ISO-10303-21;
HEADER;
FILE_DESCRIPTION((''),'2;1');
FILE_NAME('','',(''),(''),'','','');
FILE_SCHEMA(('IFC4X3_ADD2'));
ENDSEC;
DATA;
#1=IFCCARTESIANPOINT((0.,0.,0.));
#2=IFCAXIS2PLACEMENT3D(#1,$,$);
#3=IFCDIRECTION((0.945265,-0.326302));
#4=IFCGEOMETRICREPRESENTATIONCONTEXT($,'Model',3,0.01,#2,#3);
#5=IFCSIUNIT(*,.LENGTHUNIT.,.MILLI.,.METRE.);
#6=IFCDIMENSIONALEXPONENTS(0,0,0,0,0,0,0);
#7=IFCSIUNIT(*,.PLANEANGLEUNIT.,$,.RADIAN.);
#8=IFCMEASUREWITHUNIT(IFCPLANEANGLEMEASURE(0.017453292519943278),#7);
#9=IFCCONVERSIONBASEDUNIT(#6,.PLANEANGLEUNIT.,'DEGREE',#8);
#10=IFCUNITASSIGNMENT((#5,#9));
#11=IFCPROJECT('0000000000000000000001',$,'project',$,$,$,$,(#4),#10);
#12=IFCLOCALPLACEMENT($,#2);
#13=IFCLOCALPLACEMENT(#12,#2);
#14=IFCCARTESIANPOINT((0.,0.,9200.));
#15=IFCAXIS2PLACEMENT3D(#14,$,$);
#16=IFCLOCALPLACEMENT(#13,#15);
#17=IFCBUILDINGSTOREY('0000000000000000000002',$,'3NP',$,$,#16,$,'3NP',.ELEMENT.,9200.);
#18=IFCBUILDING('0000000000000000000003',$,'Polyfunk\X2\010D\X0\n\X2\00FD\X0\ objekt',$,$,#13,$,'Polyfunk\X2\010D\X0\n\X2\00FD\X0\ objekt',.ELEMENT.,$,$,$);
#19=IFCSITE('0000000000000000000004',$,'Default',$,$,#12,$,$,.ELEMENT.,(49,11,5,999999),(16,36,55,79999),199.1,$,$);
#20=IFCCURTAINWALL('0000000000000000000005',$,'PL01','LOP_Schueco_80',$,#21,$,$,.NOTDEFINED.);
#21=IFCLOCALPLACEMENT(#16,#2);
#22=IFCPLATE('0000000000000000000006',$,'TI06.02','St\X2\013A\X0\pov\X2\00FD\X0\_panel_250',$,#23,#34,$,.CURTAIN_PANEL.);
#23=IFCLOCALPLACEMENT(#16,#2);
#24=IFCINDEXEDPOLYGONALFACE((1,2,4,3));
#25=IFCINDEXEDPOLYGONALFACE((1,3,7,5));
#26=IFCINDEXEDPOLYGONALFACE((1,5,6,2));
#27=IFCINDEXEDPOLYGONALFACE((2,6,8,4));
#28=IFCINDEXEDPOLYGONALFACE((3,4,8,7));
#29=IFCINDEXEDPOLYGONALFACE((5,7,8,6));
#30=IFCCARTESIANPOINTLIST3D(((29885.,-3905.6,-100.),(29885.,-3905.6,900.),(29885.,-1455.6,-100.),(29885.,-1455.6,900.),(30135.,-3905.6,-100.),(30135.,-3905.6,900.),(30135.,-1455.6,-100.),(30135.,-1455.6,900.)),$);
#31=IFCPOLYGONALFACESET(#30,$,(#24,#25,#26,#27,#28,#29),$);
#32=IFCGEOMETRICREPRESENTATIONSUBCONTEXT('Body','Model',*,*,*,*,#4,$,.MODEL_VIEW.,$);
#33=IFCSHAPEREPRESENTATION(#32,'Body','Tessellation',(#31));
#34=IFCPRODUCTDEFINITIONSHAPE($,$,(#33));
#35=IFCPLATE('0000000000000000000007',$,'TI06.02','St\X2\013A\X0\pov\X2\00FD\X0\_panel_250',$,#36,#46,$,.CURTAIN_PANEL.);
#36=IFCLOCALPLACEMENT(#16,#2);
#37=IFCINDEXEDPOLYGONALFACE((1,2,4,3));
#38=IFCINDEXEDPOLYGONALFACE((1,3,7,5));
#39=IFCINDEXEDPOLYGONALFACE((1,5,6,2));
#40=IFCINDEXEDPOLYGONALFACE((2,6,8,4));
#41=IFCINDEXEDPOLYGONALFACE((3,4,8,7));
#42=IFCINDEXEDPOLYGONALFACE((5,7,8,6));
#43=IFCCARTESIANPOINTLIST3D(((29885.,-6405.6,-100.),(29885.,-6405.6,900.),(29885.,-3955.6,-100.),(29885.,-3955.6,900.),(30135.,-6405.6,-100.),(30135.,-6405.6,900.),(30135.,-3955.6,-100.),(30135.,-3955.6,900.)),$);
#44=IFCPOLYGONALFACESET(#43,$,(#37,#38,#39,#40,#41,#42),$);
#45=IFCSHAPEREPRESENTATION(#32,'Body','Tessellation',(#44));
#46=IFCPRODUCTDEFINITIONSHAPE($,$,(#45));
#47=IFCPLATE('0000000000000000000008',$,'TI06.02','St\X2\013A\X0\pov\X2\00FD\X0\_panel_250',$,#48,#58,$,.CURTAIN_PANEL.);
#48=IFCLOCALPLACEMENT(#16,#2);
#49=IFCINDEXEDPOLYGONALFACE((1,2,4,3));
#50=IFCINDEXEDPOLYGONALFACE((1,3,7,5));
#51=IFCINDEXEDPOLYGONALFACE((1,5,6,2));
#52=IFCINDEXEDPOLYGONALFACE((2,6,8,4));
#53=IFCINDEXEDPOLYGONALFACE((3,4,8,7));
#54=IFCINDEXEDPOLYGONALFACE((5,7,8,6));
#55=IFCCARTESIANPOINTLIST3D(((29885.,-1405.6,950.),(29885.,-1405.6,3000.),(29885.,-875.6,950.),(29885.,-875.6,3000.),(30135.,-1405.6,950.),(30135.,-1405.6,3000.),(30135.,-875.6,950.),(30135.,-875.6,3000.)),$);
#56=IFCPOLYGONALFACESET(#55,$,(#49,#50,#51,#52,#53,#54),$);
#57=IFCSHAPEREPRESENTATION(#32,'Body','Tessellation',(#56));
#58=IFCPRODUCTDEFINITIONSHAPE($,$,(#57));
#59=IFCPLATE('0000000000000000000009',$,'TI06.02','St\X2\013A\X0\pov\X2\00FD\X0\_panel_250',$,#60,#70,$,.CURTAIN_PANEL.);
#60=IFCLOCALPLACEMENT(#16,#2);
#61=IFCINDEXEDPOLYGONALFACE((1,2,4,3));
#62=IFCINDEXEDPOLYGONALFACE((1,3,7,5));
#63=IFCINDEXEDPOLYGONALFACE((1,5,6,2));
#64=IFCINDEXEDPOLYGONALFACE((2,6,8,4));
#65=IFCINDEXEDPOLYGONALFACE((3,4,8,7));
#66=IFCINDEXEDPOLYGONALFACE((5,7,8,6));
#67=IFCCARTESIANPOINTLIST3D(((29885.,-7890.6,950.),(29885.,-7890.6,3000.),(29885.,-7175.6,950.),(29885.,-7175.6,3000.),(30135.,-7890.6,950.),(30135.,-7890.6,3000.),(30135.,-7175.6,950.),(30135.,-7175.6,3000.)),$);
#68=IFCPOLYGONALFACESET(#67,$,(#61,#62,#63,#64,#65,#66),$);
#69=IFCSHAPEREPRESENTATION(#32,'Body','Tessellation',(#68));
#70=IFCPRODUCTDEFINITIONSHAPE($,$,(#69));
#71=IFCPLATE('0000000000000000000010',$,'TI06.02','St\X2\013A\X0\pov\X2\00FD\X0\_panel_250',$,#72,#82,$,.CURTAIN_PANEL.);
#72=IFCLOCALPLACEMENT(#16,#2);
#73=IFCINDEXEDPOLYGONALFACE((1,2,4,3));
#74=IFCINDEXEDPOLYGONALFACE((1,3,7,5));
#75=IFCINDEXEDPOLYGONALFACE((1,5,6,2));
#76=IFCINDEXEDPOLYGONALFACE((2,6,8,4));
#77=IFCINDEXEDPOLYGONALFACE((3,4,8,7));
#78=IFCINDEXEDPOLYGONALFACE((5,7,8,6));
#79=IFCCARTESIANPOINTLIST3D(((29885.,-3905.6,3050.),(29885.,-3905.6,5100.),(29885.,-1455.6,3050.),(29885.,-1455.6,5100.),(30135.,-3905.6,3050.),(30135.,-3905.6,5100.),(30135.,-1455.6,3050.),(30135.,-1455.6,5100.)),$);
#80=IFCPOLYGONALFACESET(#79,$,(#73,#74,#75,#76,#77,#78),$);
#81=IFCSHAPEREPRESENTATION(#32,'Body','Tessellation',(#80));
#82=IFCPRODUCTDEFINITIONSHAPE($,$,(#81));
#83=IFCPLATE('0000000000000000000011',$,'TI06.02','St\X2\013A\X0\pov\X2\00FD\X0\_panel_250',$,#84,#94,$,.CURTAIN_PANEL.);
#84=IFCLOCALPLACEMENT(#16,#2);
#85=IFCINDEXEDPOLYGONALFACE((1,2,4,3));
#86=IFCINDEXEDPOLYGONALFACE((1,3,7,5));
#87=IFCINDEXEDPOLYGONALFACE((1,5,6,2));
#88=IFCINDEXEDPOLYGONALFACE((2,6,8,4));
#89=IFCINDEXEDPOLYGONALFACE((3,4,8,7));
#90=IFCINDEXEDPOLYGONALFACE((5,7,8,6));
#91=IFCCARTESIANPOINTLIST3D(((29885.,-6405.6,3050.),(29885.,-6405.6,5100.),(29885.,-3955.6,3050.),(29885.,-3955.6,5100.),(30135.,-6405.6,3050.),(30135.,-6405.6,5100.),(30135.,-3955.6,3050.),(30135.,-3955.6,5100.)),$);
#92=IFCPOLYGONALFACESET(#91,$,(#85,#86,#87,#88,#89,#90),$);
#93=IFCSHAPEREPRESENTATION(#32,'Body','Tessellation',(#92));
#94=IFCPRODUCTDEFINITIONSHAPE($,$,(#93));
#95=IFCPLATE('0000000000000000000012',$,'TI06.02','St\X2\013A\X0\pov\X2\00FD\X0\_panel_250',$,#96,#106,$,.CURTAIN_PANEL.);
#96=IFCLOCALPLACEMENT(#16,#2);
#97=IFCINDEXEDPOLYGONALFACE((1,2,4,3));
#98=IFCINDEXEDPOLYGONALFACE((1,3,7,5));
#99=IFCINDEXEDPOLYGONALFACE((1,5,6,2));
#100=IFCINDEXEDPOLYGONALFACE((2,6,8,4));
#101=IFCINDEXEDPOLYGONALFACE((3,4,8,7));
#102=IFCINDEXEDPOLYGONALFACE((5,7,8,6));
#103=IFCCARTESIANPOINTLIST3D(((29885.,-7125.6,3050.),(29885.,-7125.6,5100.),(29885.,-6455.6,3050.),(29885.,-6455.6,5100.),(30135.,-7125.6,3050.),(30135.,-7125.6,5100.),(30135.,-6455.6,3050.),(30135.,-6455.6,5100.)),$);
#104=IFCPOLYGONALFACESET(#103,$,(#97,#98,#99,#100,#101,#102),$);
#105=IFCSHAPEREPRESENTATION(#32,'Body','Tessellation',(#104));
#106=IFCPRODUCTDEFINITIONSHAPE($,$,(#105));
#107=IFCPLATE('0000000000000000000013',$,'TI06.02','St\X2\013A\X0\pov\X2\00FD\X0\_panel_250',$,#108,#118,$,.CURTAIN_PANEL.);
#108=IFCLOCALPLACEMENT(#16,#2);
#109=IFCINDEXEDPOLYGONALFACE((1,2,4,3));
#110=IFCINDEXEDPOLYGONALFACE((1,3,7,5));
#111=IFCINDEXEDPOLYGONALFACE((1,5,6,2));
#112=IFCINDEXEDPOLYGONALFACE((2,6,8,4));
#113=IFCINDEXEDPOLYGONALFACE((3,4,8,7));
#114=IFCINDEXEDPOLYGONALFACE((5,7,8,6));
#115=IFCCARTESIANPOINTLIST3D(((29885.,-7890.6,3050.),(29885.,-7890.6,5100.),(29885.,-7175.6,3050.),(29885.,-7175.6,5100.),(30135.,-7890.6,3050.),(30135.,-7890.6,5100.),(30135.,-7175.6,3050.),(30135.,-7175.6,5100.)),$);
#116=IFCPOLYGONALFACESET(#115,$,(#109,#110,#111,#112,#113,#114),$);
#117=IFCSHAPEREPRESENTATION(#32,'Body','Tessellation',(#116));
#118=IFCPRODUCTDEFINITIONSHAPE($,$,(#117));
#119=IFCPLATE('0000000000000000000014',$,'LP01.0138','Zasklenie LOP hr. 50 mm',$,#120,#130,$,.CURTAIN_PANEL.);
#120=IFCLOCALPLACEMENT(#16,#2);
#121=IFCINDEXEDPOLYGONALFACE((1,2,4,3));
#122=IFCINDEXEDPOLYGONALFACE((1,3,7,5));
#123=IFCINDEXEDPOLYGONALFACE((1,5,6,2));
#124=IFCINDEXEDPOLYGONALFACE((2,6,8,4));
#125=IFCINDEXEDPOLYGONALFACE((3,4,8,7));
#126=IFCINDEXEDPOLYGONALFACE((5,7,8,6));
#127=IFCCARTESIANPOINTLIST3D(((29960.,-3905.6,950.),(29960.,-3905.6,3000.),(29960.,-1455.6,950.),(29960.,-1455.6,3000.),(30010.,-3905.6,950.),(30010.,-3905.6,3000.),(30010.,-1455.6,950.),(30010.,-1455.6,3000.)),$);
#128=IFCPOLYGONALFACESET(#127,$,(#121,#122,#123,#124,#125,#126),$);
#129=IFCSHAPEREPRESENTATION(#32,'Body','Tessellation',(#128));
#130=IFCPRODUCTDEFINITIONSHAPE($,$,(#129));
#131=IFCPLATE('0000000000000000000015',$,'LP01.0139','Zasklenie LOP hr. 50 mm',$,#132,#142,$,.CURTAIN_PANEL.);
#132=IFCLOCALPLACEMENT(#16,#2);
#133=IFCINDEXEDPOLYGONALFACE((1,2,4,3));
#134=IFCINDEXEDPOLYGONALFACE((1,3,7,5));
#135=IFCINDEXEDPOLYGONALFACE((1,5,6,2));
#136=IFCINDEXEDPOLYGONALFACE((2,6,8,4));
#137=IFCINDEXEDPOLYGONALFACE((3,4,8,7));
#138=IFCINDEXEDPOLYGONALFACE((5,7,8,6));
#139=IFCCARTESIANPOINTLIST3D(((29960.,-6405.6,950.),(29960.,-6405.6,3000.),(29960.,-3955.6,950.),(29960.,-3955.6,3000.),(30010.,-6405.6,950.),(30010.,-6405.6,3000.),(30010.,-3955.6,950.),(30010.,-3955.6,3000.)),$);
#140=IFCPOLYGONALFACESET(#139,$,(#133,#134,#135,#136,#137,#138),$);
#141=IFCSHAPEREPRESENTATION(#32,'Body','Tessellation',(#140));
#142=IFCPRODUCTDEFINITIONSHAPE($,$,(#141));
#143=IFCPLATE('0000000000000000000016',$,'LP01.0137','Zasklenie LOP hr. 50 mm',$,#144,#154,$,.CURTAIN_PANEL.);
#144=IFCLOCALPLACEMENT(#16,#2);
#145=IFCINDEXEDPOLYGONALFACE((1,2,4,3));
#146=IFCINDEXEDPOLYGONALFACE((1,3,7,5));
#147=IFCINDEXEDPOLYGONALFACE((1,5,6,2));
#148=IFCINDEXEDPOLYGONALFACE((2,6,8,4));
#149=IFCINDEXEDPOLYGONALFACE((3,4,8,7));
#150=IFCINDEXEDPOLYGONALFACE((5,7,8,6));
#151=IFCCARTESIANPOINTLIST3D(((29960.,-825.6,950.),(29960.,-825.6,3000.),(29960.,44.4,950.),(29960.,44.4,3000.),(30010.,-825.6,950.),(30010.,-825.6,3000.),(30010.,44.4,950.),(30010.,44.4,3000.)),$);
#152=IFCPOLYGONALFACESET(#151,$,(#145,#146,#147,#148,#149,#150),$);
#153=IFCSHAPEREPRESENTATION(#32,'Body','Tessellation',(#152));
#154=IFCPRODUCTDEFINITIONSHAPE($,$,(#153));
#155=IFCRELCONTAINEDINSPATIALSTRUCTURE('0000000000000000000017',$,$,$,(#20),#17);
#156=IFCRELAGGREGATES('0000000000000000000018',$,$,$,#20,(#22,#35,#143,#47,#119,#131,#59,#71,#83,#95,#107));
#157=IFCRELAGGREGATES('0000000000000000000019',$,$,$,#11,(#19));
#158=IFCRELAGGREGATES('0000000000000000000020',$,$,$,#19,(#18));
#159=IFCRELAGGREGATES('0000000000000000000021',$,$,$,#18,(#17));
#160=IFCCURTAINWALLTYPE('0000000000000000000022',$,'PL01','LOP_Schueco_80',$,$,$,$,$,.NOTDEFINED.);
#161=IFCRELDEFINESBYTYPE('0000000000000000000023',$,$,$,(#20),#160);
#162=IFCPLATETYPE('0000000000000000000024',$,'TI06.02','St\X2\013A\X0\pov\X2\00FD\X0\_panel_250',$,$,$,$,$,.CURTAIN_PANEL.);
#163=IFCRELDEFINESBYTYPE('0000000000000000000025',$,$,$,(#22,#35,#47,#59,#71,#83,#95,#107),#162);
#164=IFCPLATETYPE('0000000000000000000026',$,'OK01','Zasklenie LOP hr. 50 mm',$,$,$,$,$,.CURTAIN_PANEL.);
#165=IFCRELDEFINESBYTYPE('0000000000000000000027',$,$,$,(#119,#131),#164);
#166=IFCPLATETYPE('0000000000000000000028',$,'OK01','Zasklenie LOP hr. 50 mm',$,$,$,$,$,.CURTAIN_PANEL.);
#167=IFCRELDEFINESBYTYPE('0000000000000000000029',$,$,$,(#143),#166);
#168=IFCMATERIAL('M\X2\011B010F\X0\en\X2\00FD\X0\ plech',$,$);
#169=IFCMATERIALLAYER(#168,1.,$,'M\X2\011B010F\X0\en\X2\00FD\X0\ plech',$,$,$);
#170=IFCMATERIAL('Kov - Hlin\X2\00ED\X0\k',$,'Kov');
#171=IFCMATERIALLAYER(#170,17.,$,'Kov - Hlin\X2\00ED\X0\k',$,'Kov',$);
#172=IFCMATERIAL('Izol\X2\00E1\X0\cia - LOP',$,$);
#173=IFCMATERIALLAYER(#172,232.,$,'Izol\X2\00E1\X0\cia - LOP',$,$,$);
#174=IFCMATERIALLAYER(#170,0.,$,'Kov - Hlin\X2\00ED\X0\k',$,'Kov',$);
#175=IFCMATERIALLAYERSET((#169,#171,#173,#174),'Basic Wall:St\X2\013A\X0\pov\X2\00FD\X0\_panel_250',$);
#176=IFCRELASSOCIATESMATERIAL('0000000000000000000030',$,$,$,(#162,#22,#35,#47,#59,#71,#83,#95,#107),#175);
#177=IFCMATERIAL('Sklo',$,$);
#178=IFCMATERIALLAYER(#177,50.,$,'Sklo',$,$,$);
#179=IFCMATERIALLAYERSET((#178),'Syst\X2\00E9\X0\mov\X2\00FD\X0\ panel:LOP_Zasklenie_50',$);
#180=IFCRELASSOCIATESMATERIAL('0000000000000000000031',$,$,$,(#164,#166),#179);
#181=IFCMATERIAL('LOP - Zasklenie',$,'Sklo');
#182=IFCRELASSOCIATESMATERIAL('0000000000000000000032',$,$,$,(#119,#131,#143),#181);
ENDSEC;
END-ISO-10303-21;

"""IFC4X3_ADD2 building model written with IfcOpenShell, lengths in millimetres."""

from ifc_helpers import new_model, entity, si_unit, converted_unit, direction, frame, frame_2d, origin, origin_2d_with_axis, place, context, subcontext, project, spatial, rectangle, extrude, source, transform, mapped, material, layer, layer_set, layer_usage, type_object, type_shapes, element, aggregate, save


model = new_model("IFC4X3_ADD2")

# Units and contexts
model_context = context("Model", 3, precision=0.01, world=origin(), true_north=direction((0.945265, -0.326302)))
body_context = subcontext(model_context, "Body", "Model", "MODEL_VIEW")
ifc_project = project(units=[si_unit("LENGTHUNIT", "METRE", prefix="MILLI"), converted_unit("PLANEANGLEUNIT", "DEGREE", entity("IfcPlaneAngleMeasure", 0.017453292519943278), si_unit("PLANEANGLEUNIT", "RADIAN"), dimensions=[0, 0, 0, 0, 0, 0, 0])], contexts=[model_context])

# Site, building, storey
site_placement = place(None, origin())
site = spatial("IfcSite", under=ifc_project, at=site_placement, Name="Default", CompositionType="ELEMENT", RefLatitude=(49, 11, 5, 999999), RefLongitude=(16, 36, 55, 79999), RefElevation=199.1)
building_placement = place(site_placement, origin())
building = spatial("IfcBuilding", under=site, at=building_placement, Name="Polyfunkčný objekt", LongName="Polyfunkčný objekt", CompositionType="ELEMENT")
storey_placement = place(building_placement, frame((0.0, 0.0, 9200.0)))
storey = spatial("IfcBuildingStorey", under=building, at=storey_placement, Name="3NP", LongName="3NP", CompositionType="ELEMENT", Elevation=9200.0)

# Curtain wall, plates
curtain_wall_type = type_object("IfcCurtainWallType", Name="PL01", Description="LOP_Schueco_80", PredefinedType="NOTDEFINED")
curtain_wall_placement = place(storey_placement, frame((0.0, 0.0, -9200.0)))
curtain_wall = element("IfcCurtainWall", 1, at=curtain_wall_placement, inside=storey, type_object=curtain_wall_type, Name="PL01", Description="LOP_Schueco_80", PredefinedType="NOTDEFINED")
ifc_material_1 = material(Name="Měďený plech")
ifc_layer_1 = layer(ifc_material_1, 1.0, Name="Měďený plech")
ifc_material_2 = material(Name="Kov - Hliník", Category="Kov")
ifc_layer_2 = layer(ifc_material_2, 17.0, Name="Kov - Hliník", Category="Kov")
ifc_material_3 = material(Name="Izolácia - LOP")
ifc_layer_3 = layer(ifc_material_3, 232.0, Name="Izolácia - LOP")
ifc_layer_4 = layer(ifc_material_2, 0.0, Name="Kov - Hliník", Category="Kov")
ifc_layer_set_1 = layer_set([ifc_layer_1, ifc_layer_2, ifc_layer_3, ifc_layer_4], Name="Basic Wall:Stĺpový_panel_250")
ifc_layer_usage_1 = layer_usage(ifc_layer_set_1, "AXIS2", "POSITIVE", -125.0)
plate_type_1 = type_object("IfcPlateType", Name="TI06.02", Description="Stĺpový_panel_250", PredefinedType="CURTAIN_PANEL", material=ifc_layer_set_1)
plate_1_placement = place(storey_placement, frame((30010.0, -1455.6, -100.0), z_axis=(0.0, 0.0, 1.0), x_axis=(0.0, -1.0, 0.0)))
plate_1 = element("IfcPlate", 2, at=plate_1_placement, type_object=plate_type_1, material=ifc_layer_usage_1, Name="TI06.02", Description="Stĺpový_panel_250", PredefinedType="CURTAIN_PANEL", context=body_context, shape_type="SweptSolid", body=[
    extrude(rectangle(XDim=250.0, YDim=2450.0, at=origin_2d_with_axis()), frame((1225.0, 0.0, 0.0), z_axis=(0.0, 0.0, 1.0), x_axis=(0.0, 1.0, 0.0)), (0.0, 0.0, 1.0), 1000.0),
])
ifc_layer_usage_2 = layer_usage(ifc_layer_set_1, "AXIS2", "POSITIVE", -125.0)
plate_2_placement = place(storey_placement, frame((30010.0, -3955.6, -100.0), z_axis=(0.0, 0.0, 1.0), x_axis=(0.0, -1.0, 0.0)))
plate_2 = element("IfcPlate", 3, at=plate_2_placement, type_object=plate_type_1, material=ifc_layer_usage_2, Name="TI06.02", Description="Stĺpový_panel_250", PredefinedType="CURTAIN_PANEL", context=body_context, shape_type="SweptSolid", body=[
    extrude(rectangle(XDim=250.0, YDim=2450.0, at=frame_2d((0.0, 0.0), x_axis=(1.0, 0.0))), frame((1225.0, 0.0, 0.0), z_axis=(0.0, 0.0, 1.0), x_axis=(0.0, 1.0, 0.0)), (0.0, 0.0, 1.0), 1000.0),
])
ifc_layer_usage_3 = layer_usage(ifc_layer_set_1, "AXIS2", "POSITIVE", -125.0)
plate_3_placement = place(storey_placement, frame((30010.0, -875.6, 950.0), z_axis=(0.0, 0.0, 1.0), x_axis=(0.0, -1.0, 0.0)))
plate_3 = element("IfcPlate", 4, at=plate_3_placement, type_object=plate_type_1, material=ifc_layer_usage_3, Name="TI06.02", Description="Stĺpový_panel_250", PredefinedType="CURTAIN_PANEL", context=body_context, shape_type="SweptSolid", body=[
    extrude(rectangle(XDim=250.0, YDim=530.0, at=frame_2d((0.0, 0.0), x_axis=(1.0, 0.0))), frame((265.0, 0.0, 0.0), z_axis=(0.0, 0.0, 1.0), x_axis=(0.0, 1.0, 0.0)), (0.0, 0.0, 1.0), 2050.0),
])
ifc_layer_usage_4 = layer_usage(ifc_layer_set_1, "AXIS2", "POSITIVE", -125.0)
plate_4_placement = place(storey_placement, frame((30010.0, -7175.6, 950.0), z_axis=(0.0, 0.0, 1.0), x_axis=(0.0, -1.0, 0.0)))
plate_4 = element("IfcPlate", 5, at=plate_4_placement, type_object=plate_type_1, material=ifc_layer_usage_4, Name="TI06.02", Description="Stĺpový_panel_250", PredefinedType="CURTAIN_PANEL", context=body_context, shape_type="SweptSolid", body=[
    extrude(rectangle(XDim=250.0, YDim=715.0, at=frame_2d((0.0, 0.0), x_axis=(1.0, 0.0))), frame((357.5, 0.0, 0.0), z_axis=(0.0, 0.0, 1.0), x_axis=(0.0, 1.0, 0.0)), (0.0, 0.0, 1.0), 2050.0),
])
ifc_layer_usage_5 = layer_usage(ifc_layer_set_1, "AXIS2", "POSITIVE", -125.0)
plate_5_placement = place(storey_placement, frame((30010.0, -1455.6, 3050.0), z_axis=(0.0, 0.0, 1.0), x_axis=(0.0, -1.0, 0.0)))
plate_5 = element("IfcPlate", 6, at=plate_5_placement, type_object=plate_type_1, material=ifc_layer_usage_5, Name="TI06.02", Description="Stĺpový_panel_250", PredefinedType="CURTAIN_PANEL", context=body_context, shape_type="SweptSolid", body=[
    extrude(rectangle(XDim=250.0, YDim=2450.0, at=origin_2d_with_axis()), frame((1225.0, 0.0, 0.0), z_axis=(0.0, 0.0, 1.0), x_axis=(0.0, 1.0, 0.0)), (0.0, 0.0, 1.0), 2050.0),
])
ifc_layer_usage_6 = layer_usage(ifc_layer_set_1, "AXIS2", "POSITIVE", -125.0)
plate_6_placement = place(storey_placement, frame((30010.0, -3955.6, 3050.0), z_axis=(0.0, 0.0, 1.0), x_axis=(0.0, -1.0, 0.0)))
plate_6 = element("IfcPlate", 7, at=plate_6_placement, type_object=plate_type_1, material=ifc_layer_usage_6, Name="TI06.02", Description="Stĺpový_panel_250", PredefinedType="CURTAIN_PANEL", context=body_context, shape_type="SweptSolid", body=[
    extrude(rectangle(XDim=250.0, YDim=2450.0, at=frame_2d((0.0, 0.0), x_axis=(1.0, 0.0))), frame((1225.0, 0.0, 0.0), z_axis=(0.0, 0.0, 1.0), x_axis=(0.0, 1.0, 0.0)), (0.0, 0.0, 1.0), 2050.0),
])
ifc_layer_usage_7 = layer_usage(ifc_layer_set_1, "AXIS2", "POSITIVE", -125.0)
plate_7_placement = place(storey_placement, frame((30010.0, -6455.6, 3050.0), z_axis=(0.0, 0.0, 1.0), x_axis=(0.0, -1.0, 0.0)))
plate_7 = element("IfcPlate", 8, at=plate_7_placement, type_object=plate_type_1, material=ifc_layer_usage_7, Name="TI06.02", Description="Stĺpový_panel_250", PredefinedType="CURTAIN_PANEL", context=body_context, shape_type="SweptSolid", body=[
    extrude(rectangle(XDim=250.0, YDim=670.0, at=frame_2d((0.0, 0.0), x_axis=(1.0, 0.0))), frame((335.0, 0.0, 0.0), z_axis=(0.0, 0.0, 1.0), x_axis=(0.0, 1.0, 0.0)), (0.0, 0.0, 1.0), 2050.0),
])
ifc_layer_usage_8 = layer_usage(ifc_layer_set_1, "AXIS2", "POSITIVE", -125.0)
plate_8_placement = place(storey_placement, frame((30010.0, -7175.6, 3050.0), z_axis=(0.0, 0.0, 1.0), x_axis=(0.0, -1.0, 0.0)))
plate_8 = element("IfcPlate", 9, at=plate_8_placement, type_object=plate_type_1, material=ifc_layer_usage_8, Name="TI06.02", Description="Stĺpový_panel_250", PredefinedType="CURTAIN_PANEL", context=body_context, shape_type="SweptSolid", body=[
    extrude(rectangle(XDim=250.0, YDim=715.0, at=frame_2d((0.0, 0.0), x_axis=(1.0, 0.0))), frame((357.5, 0.0, 0.0), z_axis=(0.0, 0.0, 1.0), x_axis=(0.0, 1.0, 0.0)), (0.0, 0.0, 1.0), 2050.0),
])
ifc_material_4 = material(Name="LOP - Zasklenie", Category="Sklo")
ifc_material_5 = material(Name="Sklo")
ifc_layer_5 = layer(ifc_material_5, 50.0, Name="Sklo")
ifc_layer_set_2 = layer_set([ifc_layer_5], Name="Systémový panel:LOP_Zasklenie_50")
plate_type_2 = type_object("IfcPlateType", Name="OK01", Description="Zasklenie LOP hr. 50 mm", PredefinedType="CURTAIN_PANEL", material=ifc_layer_set_2)
shared_shape_1 = source(origin(), body_context, "Body", "SweptSolid", [
    extrude(rectangle(XDim=50.0, YDim=2450.0, at=origin_2d_with_axis()), frame((0.0, -25.0, 0.0), z_axis=(0.0, 0.0, 1.0), x_axis=(0.0, 1.0, 0.0)), (0.0, 0.0, 1.0), 2050.0),
])
type_shapes(plate_type_2, [shared_shape_1])
plate_9_placement = place(curtain_wall_placement, frame((30010.0, -2680.6, 10150.0), z_axis=(0.0, 0.0, 1.0), x_axis=(0.0, -1.0, 0.0)))
plate_9 = element("IfcPlate", 10, at=plate_9_placement, type_object=plate_type_2, material=ifc_material_4, Name="LP01.0138", Description="Zasklenie LOP hr. 50 mm", PredefinedType="CURTAIN_PANEL", context=body_context, shape_type="MappedRepresentation", body=[
    mapped(shared_shape_1, transform((0.0, 0.0, 0.0), scale=1.0)),
])
plate_10_placement = place(curtain_wall_placement, frame((30010.0, -5180.6, 10150.0), z_axis=(0.0, 0.0, 1.0), x_axis=(0.0, -1.0, 0.0)))
plate_10 = element("IfcPlate", 11, at=plate_10_placement, type_object=plate_type_2, material=ifc_material_4, Name="LP01.0139", Description="Zasklenie LOP hr. 50 mm", PredefinedType="CURTAIN_PANEL", context=body_context, shape_type="MappedRepresentation", body=[
    mapped(shared_shape_1, transform((0.0, 0.0, 0.0), scale=1.0)),
])
plate_type_3 = type_object("IfcPlateType", Name="OK01", Description="Zasklenie LOP hr. 50 mm", PredefinedType="CURTAIN_PANEL", material=ifc_layer_set_2)
shared_shape_2 = source(origin(), body_context, "Body", "SweptSolid", [
    extrude(rectangle(XDim=50.0, YDim=870.0, at=origin_2d_with_axis()), frame((0.0, -25.0, 0.0), z_axis=(0.0, 0.0, 1.0), x_axis=(0.0, 1.0, 0.0)), (0.0, 0.0, 1.0), 2050.0),
])
type_shapes(plate_type_3, [shared_shape_2])
plate_11_placement = place(curtain_wall_placement, frame((30010.0, -390.6, 10150.0), z_axis=(0.0, 0.0, 1.0), x_axis=(0.0, -1.0, 0.0)))
plate_11 = element("IfcPlate", 12, at=plate_11_placement, type_object=plate_type_3, material=ifc_material_4, Name="LP01.0137", Description="Zasklenie LOP hr. 50 mm", PredefinedType="CURTAIN_PANEL", context=body_context, shape_type="MappedRepresentation", body=[
    mapped(shared_shape_2, transform((0.0, 0.0, 0.0), scale=1.0)),
])
aggregate(curtain_wall, [plate_1, plate_2, plate_11, plate_3, plate_9, plate_10, plate_4, plate_5, plate_6, plate_7, plate_8])

save(model, "model.ifc")
